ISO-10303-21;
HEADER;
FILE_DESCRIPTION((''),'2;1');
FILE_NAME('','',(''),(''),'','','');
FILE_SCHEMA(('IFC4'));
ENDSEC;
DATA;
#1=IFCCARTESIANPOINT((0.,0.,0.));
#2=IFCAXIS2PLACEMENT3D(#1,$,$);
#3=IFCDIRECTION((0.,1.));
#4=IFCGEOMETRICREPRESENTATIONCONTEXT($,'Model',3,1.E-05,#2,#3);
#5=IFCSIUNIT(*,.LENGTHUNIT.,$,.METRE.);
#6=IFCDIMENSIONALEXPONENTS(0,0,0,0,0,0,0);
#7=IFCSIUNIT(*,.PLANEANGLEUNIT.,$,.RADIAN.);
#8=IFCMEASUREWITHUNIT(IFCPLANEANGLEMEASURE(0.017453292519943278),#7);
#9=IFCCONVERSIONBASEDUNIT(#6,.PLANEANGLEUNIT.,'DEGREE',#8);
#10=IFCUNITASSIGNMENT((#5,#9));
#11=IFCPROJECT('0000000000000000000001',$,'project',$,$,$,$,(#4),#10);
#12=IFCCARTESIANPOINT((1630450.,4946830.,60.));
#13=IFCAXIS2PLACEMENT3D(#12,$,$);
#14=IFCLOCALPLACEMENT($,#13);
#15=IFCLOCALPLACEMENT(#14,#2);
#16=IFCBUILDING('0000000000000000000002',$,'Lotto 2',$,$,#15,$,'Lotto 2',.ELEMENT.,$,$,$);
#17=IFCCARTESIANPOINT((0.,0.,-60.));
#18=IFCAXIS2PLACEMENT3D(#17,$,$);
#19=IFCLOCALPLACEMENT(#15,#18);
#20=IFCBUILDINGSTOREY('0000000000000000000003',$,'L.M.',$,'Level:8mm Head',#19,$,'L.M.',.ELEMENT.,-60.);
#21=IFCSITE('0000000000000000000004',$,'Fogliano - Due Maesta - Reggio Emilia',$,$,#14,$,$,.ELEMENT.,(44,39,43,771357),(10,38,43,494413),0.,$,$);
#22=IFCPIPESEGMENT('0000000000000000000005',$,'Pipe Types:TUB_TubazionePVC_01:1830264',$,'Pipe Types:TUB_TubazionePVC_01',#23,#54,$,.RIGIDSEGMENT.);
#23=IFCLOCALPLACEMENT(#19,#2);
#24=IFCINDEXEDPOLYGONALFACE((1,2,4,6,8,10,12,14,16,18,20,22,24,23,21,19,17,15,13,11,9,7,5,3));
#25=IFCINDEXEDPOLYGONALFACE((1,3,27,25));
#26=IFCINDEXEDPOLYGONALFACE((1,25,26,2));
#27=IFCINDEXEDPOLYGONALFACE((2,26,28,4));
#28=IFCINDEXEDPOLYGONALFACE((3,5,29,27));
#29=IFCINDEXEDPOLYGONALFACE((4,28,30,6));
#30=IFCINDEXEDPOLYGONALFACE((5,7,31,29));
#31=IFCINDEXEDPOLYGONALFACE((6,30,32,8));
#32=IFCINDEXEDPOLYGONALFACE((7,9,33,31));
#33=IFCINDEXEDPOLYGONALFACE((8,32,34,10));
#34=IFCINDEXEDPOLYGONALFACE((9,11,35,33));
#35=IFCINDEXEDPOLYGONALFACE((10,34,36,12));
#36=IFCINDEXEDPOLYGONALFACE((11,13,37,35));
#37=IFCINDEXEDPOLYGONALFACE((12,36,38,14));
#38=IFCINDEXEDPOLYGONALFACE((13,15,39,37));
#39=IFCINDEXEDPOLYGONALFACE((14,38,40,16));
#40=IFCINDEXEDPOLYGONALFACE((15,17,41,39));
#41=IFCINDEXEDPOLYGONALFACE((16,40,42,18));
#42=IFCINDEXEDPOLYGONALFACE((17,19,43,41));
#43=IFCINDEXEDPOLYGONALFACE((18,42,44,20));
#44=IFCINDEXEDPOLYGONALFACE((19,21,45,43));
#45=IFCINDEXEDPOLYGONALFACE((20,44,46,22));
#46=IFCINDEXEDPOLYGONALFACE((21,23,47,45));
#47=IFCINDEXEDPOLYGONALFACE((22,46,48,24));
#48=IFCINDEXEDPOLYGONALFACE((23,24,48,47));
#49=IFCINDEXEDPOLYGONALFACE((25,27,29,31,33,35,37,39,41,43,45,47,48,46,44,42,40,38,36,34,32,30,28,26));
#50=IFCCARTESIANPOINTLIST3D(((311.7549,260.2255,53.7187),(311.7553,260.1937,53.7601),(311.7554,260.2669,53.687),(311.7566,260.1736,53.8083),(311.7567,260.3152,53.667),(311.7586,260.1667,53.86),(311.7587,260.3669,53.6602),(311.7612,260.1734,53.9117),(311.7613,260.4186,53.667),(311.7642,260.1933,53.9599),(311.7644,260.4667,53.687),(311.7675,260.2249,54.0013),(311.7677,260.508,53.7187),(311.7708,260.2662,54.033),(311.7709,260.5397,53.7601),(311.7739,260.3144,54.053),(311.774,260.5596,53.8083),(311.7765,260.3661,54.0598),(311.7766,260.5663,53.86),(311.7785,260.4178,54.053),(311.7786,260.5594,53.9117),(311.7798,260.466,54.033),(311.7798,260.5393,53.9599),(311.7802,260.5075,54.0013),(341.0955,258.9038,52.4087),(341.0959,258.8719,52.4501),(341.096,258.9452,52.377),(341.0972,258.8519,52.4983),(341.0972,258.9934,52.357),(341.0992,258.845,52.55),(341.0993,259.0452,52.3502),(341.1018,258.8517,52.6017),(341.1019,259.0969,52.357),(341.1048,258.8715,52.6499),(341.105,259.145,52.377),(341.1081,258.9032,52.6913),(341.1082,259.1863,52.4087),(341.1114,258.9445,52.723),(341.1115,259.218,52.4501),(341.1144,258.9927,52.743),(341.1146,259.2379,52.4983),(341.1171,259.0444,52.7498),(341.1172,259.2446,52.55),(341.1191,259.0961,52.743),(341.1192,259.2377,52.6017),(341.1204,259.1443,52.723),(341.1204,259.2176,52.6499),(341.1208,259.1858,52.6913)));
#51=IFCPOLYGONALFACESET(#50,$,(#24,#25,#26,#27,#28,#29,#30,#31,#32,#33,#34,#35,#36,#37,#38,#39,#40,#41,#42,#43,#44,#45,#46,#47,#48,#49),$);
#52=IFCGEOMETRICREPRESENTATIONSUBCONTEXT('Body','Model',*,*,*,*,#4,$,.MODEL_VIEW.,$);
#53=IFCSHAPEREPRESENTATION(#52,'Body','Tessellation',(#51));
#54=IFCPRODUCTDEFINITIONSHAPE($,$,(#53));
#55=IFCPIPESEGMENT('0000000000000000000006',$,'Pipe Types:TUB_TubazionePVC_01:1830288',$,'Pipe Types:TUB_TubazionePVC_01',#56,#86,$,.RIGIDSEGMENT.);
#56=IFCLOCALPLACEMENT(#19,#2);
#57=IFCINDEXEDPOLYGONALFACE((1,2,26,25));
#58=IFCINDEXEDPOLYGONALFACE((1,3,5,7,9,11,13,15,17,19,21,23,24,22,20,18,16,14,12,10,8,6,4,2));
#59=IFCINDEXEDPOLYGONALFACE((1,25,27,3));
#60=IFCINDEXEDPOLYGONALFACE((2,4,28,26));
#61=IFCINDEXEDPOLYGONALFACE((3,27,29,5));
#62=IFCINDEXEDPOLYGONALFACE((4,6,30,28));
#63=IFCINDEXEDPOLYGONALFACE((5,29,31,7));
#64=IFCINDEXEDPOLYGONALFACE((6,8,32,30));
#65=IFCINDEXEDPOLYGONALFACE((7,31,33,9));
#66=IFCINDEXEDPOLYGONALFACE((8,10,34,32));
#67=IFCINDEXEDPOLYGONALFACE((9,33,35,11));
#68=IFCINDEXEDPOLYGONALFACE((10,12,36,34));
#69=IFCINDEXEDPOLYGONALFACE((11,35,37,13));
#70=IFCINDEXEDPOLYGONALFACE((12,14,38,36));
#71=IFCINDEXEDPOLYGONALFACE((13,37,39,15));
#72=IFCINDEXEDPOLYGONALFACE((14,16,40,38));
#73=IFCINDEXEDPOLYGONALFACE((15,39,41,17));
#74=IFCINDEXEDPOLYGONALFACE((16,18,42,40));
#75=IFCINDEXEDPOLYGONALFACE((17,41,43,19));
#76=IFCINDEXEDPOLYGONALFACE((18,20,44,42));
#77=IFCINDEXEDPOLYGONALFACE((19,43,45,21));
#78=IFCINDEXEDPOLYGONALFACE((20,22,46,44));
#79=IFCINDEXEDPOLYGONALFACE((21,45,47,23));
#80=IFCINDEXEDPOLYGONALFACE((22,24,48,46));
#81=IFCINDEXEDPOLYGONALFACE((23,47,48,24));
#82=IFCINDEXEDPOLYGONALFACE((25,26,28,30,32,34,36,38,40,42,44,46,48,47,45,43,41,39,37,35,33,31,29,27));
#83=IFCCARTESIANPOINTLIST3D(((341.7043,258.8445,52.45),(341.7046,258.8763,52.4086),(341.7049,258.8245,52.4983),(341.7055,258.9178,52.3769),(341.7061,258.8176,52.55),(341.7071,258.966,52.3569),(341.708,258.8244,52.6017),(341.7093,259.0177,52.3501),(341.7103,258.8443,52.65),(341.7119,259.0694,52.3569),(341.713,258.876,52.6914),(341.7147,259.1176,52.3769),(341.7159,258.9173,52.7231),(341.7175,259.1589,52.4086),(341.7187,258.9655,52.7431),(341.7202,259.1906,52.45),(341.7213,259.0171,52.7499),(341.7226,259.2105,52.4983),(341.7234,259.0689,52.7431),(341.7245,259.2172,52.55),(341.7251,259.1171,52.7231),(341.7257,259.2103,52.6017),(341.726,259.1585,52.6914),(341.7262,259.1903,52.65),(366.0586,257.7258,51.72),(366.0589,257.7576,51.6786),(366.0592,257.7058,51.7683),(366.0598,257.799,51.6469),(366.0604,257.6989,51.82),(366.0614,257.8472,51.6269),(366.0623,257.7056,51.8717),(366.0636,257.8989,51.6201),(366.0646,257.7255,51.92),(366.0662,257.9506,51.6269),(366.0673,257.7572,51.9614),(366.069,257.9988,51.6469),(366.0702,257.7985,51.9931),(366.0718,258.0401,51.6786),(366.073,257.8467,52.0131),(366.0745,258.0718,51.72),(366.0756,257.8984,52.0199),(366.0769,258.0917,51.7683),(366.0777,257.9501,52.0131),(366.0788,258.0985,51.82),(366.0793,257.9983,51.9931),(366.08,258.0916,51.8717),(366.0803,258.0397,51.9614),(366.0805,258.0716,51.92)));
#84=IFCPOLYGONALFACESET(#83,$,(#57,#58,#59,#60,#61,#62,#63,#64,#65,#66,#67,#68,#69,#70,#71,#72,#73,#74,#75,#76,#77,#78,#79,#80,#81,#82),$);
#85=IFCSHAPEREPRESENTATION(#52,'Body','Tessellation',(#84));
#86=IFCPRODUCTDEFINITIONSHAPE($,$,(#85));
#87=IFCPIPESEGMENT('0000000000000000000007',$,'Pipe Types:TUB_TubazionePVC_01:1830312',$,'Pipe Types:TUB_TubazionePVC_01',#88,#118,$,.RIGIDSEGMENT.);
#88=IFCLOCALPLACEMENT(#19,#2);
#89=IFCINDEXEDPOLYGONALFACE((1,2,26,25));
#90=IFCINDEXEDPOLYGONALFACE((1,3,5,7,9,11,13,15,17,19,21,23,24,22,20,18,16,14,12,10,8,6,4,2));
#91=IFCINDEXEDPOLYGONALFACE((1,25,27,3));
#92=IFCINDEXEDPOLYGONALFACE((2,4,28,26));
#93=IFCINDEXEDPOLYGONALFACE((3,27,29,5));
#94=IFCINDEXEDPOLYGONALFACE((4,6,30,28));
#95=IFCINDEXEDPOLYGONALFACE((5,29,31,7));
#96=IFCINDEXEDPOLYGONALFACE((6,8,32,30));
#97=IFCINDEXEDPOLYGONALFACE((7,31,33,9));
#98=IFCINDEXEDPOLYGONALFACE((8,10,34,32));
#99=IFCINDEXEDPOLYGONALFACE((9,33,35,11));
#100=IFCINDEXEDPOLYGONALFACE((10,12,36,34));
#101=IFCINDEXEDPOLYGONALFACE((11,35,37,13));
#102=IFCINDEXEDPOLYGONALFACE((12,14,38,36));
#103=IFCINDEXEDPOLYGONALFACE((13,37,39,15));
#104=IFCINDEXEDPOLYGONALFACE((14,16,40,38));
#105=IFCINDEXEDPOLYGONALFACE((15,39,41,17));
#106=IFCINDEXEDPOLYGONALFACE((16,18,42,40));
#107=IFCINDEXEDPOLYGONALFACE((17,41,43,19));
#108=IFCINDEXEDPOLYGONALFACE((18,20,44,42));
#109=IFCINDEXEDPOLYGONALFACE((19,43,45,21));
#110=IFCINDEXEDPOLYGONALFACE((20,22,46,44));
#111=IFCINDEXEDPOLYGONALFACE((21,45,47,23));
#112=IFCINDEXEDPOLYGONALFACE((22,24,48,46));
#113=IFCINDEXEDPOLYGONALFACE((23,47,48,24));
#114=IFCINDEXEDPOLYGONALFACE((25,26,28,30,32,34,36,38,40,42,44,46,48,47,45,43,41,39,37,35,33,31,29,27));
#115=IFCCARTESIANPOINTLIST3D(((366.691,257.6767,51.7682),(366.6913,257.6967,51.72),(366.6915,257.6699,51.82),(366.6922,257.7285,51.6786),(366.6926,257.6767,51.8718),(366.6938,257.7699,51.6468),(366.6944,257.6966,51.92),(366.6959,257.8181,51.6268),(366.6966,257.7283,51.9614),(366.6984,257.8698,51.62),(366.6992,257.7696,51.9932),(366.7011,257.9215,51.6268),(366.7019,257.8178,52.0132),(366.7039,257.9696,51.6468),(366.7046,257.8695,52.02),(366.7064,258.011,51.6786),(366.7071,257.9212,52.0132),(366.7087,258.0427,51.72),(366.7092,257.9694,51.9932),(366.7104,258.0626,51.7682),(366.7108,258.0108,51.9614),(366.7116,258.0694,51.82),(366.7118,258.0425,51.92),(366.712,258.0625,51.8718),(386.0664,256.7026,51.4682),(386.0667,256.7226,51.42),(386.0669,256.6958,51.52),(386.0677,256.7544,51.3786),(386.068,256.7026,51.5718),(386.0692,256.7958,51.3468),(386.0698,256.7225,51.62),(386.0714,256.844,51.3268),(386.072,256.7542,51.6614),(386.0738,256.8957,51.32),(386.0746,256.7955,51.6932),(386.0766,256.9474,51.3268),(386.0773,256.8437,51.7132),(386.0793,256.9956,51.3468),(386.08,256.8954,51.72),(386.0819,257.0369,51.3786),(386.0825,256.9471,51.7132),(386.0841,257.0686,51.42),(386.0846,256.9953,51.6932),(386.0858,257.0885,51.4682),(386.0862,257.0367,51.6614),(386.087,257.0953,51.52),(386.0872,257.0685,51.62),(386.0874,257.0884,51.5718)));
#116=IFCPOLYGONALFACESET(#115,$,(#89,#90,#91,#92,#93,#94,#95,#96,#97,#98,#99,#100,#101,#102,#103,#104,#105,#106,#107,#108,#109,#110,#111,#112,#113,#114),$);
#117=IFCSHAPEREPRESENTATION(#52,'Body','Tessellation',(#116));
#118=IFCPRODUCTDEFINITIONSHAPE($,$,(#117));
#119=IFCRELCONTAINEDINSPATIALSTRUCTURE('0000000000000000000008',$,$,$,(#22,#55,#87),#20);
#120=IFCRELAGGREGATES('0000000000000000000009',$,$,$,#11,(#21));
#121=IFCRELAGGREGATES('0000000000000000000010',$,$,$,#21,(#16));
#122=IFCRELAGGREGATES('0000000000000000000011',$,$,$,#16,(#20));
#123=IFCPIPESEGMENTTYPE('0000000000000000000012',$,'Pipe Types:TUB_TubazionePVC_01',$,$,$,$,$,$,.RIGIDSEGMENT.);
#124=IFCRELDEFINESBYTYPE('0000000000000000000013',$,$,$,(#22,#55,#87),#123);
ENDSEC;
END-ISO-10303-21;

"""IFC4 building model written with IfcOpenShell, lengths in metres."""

from ifc_helpers import new_model, entity, si_unit, converted_unit, direction, frame, origin, place, context, subcontext, project, spatial, arc, indexed_curve, outline, extrude, type_object, element, save


model = new_model("IFC4")

# Units and contexts
model_context = context("Model", 3, precision=1e-05, world=origin(), true_north=direction((0.0, 1.0)))
body_context = subcontext(model_context, "Body", "Model", "MODEL_VIEW")
ifc_project = project(units=[si_unit("LENGTHUNIT", "METRE"), converted_unit("PLANEANGLEUNIT", "DEGREE", entity("IfcPlaneAngleMeasure", 0.017453292519943278), si_unit("PLANEANGLEUNIT", "RADIAN"), dimensions=[0, 0, 0, 0, 0, 0, 0])], contexts=[model_context])

# Site, building, storey
site_placement = place(None, frame((1630450.0, 4946830.0, 60.0)))
site = spatial("IfcSite", under=ifc_project, at=site_placement, Name="Fogliano - Due Maesta - Reggio Emilia", CompositionType="ELEMENT", RefLatitude=(44, 39, 43, 771357), RefLongitude=(10, 38, 43, 494413), RefElevation=0.0)
building_placement = place(site_placement, origin())
building = spatial("IfcBuilding", under=site, at=building_placement, Name="Lotto 2", LongName="Lotto 2", CompositionType="ELEMENT")
storey_placement = place(building_placement, frame((0.0, 0.0, -60.0)))
storey = spatial("IfcBuildingStorey", under=building, at=storey_placement, Name="L.M.", ObjectType="Level:8mm Head", LongName="L.M.", CompositionType="ELEMENT", Elevation=-60.0)

# Pipe segments
pipe_segment_type = type_object("IfcPipeSegmentType", Name="Pipe Types:TUB_TubazionePVC_01", PredefinedType="RIGIDSEGMENT")
pipe_segment_1_placement = place(storey_placement, origin())
element("IfcPipeSegment", 1, at=pipe_segment_1_placement, inside=storey, type_object=pipe_segment_type, Name="Pipe Types:TUB_TubazionePVC_01:1830264", ObjectType="Pipe Types:TUB_TubazionePVC_01", PredefinedType="RIGIDSEGMENT", context=body_context, shape_type="SweptSolid", body=[
    extrude(outline(indexed_curve([(0.2, 0.0), (0.1414, 0.1414), (0.0, 0.2), (-0.1414, 0.1414), (-0.2, 0.0), (-0.1414, -0.1414), (0.0, -0.2), (0.1414, -0.1414)], segments=[arc(1, 2, 3), arc(3, 4, 5), arc(5, 6, 7), arc(7, 8, 1)], self_intersect=False)), frame((311.7676, 260.3665, 53.86), z_axis=(0.997995, -0.044957, -0.044559), x_axis=(-0.045002, -0.998987, 0.0)), (0.0, 0.0, 1.0), 29.3995),
])
pipe_segment_2_placement = place(storey_placement, origin())
element("IfcPipeSegment", 2, at=pipe_segment_2_placement, inside=storey, type_object=pipe_segment_type, Name="Pipe Types:TUB_TubazionePVC_01:1830288", ObjectType="Pipe Types:TUB_TubazionePVC_01", PredefinedType="RIGIDSEGMENT", context=body_context, shape_type="SweptSolid", body=[
    extrude(outline(indexed_curve([(0.2, 0.0), (0.1414, 0.1414), (0.0, 0.2), (-0.1414, 0.1414), (-0.2, 0.0), (-0.1414, -0.1414), (0.0, -0.2), (0.1414, -0.1414)], segments=[arc(1, 2, 3), arc(3, 4, 5), arc(5, 6, 7), arc(7, 8, 1)], self_intersect=False)), frame((366.0696, 257.8987, 51.82), z_axis=(-0.998499, 0.045868, 0.029929), x_axis=(-0.045888, -0.998947, 0.0)), (0.0, 0.0, 1.0), 24.3909),
])
pipe_segment_3_placement = place(storey_placement, origin())
element("IfcPipeSegment", 3, at=pipe_segment_3_placement, inside=storey, type_object=pipe_segment_type, Name="Pipe Types:TUB_TubazionePVC_01:1830312", ObjectType="Pipe Types:TUB_TubazionePVC_01", PredefinedType="RIGIDSEGMENT", context=body_context, shape_type="SweptSolid", body=[
    extrude(outline(indexed_curve([(0.2, 0.0), (0.1414, 0.1414), (0.0, 0.2), (-0.1414, 0.1414), (-0.2, 0.0), (-0.1414, -0.1414), (0.0, -0.2), (0.1414, -0.1414)], segments=[arc(1, 2, 3), arc(3, 4, 5), arc(5, 6, 7), arc(7, 8, 1)], self_intersect=False)), frame((366.7015, 257.8696, 51.82), z_axis=(0.998619, -0.050205, -0.015462), x_axis=(-0.050211, -0.998739, 0.0)), (0.0, 0.0, 1.0), 19.4022),
])

save(model, "model.ifc")
